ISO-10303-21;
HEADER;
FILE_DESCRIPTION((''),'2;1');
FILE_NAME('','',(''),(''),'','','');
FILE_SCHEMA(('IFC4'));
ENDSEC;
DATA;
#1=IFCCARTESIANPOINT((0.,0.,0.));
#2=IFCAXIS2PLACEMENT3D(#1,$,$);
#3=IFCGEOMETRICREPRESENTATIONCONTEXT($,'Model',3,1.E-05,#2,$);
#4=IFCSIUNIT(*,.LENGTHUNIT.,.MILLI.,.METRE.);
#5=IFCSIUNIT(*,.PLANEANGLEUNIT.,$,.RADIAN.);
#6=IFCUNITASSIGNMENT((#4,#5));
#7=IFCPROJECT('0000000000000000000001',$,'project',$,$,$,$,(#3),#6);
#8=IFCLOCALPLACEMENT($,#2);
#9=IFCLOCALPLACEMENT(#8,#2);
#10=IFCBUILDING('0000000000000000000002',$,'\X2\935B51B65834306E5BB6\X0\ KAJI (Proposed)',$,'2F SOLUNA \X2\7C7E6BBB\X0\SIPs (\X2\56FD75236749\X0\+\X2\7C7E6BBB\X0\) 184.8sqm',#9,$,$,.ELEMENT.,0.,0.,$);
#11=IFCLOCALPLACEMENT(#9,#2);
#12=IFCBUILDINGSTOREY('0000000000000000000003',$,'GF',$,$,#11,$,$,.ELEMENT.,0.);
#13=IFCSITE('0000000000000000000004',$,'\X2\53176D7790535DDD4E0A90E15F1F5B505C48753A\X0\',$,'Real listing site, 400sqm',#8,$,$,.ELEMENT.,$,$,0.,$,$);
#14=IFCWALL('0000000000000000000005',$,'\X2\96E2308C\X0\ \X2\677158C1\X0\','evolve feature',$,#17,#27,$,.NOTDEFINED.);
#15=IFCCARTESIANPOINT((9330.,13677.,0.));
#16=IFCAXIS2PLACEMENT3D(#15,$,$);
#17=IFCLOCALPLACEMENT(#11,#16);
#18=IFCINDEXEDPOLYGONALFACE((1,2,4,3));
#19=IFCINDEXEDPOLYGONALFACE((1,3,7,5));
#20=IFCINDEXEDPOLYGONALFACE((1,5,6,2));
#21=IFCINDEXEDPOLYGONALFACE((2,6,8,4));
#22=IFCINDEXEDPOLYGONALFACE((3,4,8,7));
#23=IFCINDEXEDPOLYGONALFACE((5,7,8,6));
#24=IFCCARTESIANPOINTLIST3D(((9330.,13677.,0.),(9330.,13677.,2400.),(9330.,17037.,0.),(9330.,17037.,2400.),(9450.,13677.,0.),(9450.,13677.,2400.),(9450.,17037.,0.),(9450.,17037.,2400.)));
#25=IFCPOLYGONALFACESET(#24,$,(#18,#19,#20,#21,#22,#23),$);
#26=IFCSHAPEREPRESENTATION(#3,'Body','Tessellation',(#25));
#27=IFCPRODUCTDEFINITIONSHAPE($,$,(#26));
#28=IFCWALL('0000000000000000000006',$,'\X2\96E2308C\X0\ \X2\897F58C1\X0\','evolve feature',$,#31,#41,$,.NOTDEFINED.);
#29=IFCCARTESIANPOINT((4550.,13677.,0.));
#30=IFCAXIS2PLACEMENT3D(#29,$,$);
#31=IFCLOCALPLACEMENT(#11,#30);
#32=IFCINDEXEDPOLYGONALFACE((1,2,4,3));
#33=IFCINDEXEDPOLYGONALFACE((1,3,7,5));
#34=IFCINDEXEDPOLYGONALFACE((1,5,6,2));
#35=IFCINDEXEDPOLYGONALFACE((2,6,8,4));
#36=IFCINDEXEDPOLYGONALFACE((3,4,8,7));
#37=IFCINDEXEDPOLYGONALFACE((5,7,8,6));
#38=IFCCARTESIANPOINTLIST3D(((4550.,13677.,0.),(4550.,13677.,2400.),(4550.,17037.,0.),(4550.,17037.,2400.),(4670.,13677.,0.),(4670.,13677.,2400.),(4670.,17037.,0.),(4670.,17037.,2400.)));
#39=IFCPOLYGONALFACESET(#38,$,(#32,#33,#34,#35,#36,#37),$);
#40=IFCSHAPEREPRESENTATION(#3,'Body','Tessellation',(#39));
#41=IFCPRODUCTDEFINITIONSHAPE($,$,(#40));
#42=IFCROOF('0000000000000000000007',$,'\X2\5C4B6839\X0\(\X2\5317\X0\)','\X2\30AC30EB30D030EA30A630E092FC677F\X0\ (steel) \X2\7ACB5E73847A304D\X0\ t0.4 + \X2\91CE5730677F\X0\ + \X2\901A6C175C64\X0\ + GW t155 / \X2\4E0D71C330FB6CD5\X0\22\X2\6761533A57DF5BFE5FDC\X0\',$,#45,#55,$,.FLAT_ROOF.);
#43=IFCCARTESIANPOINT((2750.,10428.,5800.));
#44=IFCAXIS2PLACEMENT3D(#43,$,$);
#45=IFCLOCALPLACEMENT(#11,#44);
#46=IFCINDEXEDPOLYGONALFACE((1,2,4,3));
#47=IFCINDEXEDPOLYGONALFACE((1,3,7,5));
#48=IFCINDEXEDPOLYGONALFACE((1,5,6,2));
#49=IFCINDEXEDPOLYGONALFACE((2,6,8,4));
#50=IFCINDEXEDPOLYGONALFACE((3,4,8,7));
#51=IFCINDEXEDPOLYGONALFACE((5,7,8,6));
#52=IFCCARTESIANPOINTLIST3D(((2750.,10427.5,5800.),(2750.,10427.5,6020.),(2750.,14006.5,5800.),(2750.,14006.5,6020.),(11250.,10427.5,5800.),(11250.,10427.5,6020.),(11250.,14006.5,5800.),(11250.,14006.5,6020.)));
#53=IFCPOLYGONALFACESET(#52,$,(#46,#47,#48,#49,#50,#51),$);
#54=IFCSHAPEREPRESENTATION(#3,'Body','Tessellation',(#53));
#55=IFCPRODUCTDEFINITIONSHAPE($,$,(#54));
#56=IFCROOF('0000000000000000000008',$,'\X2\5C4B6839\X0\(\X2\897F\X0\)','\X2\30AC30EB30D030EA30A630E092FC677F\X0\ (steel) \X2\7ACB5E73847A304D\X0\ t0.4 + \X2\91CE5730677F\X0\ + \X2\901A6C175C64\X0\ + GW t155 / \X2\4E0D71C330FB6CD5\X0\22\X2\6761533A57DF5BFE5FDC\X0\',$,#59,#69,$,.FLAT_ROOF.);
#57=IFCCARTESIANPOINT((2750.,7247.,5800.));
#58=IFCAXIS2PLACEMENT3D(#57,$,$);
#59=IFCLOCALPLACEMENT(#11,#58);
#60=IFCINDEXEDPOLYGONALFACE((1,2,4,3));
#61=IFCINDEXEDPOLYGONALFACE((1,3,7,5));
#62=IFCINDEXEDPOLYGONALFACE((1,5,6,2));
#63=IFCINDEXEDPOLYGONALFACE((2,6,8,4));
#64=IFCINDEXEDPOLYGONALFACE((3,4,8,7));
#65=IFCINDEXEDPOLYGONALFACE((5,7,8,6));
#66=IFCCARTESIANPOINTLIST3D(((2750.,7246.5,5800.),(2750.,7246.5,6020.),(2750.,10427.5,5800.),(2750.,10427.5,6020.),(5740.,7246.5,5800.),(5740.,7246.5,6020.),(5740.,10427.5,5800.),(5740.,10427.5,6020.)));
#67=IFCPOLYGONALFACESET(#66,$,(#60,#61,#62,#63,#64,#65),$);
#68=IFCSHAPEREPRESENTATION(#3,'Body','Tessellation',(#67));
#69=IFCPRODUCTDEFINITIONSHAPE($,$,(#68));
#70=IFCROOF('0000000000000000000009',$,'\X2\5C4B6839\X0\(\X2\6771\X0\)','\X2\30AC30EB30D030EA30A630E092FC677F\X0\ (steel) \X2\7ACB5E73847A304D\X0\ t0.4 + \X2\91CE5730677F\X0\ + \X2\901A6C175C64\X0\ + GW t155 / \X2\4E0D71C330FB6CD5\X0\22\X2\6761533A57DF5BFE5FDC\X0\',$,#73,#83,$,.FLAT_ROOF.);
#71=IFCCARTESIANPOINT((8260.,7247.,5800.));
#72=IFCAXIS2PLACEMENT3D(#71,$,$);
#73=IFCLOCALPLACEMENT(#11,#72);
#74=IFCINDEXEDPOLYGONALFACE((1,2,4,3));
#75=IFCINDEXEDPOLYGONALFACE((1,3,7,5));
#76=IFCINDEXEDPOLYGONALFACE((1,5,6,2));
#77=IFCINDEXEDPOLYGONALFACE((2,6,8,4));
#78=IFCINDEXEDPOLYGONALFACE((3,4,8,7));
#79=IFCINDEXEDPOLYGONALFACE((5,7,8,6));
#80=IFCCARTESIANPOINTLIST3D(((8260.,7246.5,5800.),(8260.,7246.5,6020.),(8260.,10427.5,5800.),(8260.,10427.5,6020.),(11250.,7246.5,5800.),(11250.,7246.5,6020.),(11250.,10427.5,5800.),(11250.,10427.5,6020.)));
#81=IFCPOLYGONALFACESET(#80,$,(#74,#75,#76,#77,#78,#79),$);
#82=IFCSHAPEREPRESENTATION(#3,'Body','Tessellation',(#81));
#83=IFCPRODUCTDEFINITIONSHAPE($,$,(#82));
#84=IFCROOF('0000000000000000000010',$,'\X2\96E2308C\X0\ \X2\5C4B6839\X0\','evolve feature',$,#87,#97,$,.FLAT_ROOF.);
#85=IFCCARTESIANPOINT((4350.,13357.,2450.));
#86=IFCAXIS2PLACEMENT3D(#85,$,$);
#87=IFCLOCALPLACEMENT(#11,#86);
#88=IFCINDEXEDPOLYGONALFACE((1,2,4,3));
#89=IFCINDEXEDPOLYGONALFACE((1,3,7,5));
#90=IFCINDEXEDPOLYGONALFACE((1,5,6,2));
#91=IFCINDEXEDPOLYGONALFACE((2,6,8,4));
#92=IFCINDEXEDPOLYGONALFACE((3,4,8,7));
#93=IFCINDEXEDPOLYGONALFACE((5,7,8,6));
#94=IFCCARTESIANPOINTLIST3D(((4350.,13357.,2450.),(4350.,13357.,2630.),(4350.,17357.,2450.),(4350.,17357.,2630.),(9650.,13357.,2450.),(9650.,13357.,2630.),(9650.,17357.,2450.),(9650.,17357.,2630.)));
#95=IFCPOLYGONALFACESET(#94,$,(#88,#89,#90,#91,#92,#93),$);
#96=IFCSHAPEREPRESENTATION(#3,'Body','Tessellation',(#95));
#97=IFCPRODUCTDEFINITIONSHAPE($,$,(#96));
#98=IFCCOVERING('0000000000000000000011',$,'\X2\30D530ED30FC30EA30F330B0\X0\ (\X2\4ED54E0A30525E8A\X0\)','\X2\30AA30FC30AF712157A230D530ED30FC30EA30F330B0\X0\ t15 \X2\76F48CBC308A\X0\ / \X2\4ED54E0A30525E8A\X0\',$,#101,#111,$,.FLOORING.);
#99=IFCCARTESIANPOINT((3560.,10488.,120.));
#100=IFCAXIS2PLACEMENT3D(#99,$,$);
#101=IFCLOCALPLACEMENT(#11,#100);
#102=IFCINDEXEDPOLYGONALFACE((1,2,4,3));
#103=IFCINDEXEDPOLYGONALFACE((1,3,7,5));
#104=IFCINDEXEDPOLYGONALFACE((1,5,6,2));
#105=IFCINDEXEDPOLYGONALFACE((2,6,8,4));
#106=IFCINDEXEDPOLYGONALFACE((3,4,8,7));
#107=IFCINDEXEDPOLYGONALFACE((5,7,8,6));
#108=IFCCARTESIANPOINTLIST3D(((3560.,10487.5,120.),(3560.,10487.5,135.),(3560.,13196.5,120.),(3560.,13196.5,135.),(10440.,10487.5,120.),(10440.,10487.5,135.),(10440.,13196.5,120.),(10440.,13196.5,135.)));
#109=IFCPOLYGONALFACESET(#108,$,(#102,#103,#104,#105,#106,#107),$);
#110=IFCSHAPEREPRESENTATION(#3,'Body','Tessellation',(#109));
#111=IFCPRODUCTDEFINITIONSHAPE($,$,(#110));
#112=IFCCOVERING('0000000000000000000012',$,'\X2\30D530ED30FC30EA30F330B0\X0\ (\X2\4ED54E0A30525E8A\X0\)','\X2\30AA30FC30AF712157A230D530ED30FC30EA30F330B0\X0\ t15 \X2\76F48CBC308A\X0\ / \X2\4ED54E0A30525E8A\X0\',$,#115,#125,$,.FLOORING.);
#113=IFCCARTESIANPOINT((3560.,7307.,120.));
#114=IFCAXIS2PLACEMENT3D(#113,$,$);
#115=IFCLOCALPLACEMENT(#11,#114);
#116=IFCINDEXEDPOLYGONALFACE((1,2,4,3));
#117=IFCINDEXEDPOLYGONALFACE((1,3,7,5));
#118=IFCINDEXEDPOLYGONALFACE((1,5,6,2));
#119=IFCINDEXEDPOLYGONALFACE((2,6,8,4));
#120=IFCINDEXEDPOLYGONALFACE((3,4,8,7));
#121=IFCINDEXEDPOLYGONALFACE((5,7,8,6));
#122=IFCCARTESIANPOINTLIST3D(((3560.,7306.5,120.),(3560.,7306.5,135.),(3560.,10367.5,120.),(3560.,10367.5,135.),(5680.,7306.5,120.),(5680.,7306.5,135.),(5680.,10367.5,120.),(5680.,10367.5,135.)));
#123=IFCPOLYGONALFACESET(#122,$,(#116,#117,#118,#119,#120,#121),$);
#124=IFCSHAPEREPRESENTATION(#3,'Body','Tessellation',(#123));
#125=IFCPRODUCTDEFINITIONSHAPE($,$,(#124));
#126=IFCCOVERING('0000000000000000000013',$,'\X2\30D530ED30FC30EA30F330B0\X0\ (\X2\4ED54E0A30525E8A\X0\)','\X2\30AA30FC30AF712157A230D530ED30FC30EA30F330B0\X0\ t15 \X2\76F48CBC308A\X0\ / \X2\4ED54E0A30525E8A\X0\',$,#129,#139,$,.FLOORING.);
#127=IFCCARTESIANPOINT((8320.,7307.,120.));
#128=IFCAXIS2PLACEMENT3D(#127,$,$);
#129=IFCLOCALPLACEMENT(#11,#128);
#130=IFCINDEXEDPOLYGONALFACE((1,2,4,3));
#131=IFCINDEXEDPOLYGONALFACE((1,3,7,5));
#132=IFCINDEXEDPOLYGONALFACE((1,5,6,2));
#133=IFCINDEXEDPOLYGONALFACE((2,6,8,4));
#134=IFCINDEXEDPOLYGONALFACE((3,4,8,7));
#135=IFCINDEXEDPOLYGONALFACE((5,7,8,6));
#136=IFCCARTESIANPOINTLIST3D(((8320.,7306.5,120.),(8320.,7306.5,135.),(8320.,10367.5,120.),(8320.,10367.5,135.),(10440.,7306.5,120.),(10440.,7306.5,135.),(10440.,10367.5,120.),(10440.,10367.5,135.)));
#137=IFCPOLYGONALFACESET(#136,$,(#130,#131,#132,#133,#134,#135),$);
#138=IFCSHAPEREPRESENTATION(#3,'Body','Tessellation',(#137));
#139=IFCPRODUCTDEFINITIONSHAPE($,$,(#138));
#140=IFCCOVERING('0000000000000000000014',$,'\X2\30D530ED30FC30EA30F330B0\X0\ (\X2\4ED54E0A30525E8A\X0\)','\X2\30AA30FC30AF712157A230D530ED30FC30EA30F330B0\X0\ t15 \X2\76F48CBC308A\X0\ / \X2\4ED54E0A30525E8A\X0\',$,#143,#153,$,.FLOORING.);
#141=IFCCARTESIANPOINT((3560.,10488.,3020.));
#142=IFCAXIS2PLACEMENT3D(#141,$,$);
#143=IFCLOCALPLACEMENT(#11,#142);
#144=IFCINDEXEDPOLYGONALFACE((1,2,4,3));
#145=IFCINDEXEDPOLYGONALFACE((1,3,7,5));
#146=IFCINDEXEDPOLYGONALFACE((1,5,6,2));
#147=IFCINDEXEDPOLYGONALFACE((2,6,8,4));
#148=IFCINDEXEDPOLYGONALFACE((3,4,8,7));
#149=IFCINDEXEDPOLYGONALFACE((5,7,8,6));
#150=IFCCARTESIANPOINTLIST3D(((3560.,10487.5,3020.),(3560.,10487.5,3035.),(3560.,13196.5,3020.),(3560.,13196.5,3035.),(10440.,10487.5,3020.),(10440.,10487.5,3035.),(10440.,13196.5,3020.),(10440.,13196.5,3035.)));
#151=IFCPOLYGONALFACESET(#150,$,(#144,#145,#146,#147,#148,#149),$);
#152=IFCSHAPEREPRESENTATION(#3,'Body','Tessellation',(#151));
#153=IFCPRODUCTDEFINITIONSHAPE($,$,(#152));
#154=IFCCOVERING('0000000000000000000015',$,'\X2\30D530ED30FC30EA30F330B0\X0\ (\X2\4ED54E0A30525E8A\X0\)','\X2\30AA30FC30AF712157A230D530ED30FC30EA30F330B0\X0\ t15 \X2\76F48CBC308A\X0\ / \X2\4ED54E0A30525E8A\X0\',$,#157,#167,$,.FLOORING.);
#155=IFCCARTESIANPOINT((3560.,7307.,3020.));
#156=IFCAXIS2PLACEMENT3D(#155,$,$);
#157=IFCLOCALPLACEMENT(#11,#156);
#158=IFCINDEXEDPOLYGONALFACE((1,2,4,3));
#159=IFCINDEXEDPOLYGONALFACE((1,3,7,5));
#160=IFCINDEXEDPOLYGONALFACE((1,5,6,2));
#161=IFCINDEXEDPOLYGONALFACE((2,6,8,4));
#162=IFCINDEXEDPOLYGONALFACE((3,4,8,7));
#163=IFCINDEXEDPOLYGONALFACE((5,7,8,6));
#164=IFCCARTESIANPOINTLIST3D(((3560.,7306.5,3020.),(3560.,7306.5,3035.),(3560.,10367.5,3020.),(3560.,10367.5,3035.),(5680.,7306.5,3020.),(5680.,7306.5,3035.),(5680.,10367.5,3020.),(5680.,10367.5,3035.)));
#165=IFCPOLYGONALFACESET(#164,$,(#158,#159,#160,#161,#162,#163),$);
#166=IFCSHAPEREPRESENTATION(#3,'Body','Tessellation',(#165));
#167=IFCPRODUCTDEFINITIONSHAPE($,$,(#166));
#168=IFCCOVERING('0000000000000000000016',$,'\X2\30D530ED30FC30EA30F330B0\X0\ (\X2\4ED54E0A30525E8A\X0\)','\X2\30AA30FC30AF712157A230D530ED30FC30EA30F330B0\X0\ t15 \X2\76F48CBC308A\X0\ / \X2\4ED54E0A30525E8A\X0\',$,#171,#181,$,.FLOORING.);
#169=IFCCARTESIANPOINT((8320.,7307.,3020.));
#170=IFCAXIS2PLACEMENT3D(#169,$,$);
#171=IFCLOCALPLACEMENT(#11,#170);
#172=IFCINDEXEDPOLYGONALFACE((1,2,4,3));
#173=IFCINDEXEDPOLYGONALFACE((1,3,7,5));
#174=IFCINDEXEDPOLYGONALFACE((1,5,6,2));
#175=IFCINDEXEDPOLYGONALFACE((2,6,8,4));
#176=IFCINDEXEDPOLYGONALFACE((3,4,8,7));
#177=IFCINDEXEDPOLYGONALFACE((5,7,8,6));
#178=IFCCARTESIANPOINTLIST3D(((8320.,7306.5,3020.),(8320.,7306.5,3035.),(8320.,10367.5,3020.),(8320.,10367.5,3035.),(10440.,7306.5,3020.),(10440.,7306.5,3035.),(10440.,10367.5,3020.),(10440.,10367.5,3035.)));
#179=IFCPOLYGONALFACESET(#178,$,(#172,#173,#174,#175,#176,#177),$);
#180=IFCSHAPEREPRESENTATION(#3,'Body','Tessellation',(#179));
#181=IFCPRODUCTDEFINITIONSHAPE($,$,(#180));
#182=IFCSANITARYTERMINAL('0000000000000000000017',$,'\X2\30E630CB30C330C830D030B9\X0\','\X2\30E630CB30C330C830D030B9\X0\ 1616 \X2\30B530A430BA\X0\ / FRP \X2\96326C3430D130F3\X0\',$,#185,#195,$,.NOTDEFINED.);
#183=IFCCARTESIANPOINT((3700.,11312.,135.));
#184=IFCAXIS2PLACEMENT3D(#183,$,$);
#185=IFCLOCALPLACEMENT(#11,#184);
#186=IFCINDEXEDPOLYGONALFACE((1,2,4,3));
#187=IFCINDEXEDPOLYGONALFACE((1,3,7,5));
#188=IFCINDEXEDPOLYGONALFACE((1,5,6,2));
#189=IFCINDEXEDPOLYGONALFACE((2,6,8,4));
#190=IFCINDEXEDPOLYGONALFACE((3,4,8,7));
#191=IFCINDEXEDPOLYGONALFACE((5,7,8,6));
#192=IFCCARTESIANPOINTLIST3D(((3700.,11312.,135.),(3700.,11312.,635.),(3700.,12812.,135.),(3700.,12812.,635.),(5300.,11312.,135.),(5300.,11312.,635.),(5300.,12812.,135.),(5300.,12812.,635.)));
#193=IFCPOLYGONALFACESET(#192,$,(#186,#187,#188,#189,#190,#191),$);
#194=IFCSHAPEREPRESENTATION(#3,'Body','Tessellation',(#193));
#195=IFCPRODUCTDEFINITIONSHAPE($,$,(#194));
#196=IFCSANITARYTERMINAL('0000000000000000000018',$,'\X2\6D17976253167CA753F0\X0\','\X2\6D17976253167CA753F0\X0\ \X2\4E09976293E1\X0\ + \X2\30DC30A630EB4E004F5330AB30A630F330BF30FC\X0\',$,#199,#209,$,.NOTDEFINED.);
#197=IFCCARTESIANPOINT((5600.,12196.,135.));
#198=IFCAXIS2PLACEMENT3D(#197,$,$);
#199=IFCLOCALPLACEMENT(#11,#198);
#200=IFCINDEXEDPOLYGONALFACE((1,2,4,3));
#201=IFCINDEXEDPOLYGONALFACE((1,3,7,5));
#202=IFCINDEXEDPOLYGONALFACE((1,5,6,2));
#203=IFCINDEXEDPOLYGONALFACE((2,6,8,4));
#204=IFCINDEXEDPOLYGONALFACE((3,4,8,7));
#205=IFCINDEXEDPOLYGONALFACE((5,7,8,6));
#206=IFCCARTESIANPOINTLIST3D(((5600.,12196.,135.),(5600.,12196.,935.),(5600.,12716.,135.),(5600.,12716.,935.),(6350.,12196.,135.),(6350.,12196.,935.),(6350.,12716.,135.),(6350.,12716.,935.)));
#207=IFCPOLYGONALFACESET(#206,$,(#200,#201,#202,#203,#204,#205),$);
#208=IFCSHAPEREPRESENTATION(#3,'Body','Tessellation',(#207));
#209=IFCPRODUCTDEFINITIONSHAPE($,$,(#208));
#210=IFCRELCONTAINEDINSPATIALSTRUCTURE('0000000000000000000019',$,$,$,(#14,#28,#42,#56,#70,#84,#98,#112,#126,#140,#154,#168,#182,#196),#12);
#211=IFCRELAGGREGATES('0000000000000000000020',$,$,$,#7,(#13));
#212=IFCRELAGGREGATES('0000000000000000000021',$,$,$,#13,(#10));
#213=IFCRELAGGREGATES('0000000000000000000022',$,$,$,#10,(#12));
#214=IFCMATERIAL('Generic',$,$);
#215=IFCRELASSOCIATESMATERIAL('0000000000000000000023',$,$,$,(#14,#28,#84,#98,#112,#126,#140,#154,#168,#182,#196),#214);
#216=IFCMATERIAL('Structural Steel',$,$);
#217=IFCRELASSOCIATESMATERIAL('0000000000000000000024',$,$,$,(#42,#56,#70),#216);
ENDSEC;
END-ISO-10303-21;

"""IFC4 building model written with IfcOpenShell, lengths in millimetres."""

from ifc_helpers import new_model, si_unit, frame, frame_2d, origin, place, context, project, spatial, rectangle, extrude, material, element, save


model = new_model("IFC4")

# Units and contexts
model_context = context("Model", 3, precision=1e-05, world=origin())
ifc_project = project(units=[si_unit("LENGTHUNIT", "METRE", prefix="MILLI"), si_unit("PLANEANGLEUNIT", "RADIAN")], contexts=[model_context])

# Site, building, storey
site_placement = place(None, origin())
site = spatial("IfcSite", under=ifc_project, at=site_placement, Name="北海道川上郡弟子屈町", ObjectType="Real listing site, 400sqm", CompositionType="ELEMENT", RefElevation=0.0)
building_placement = place(site_placement, origin())
building = spatial("IfcBuilding", under=site, at=building_placement, Name="鍛冶場の家 KAJI (Proposed)", ObjectType="2F SOLUNA 籾殻SIPs (国産杉+籾殻) 184.8sqm", CompositionType="ELEMENT", ElevationOfRefHeight=0.0, ElevationOfTerrain=0.0)
storey_placement = place(building_placement, origin())
storey = spatial("IfcBuildingStorey", under=building, at=storey_placement, Name="GF", CompositionType="ELEMENT", Elevation=0.0)

# Shared definitions
ifc_material_1 = material(Name="Generic")

# Walls
wall_1_placement = place(storey_placement, frame((9330.0, 13677.0, 0.0)))
element("IfcWall", 1, at=wall_1_placement, inside=storey, material=ifc_material_1, Name="離れ 東壁", Description="evolve feature", PredefinedType="NOTDEFINED", context=model_context, shape_type="SweptSolid", body=[
    extrude(rectangle(XDim=120.0, YDim=3360.0, at=frame_2d((60.0, 1680.0))), frame((9330.0, 13677.0, 0.0)), (0.0, 0.0, 1.0), 2400.0),
])
wall_2_placement = place(storey_placement, frame((4550.0, 13677.0, 0.0)))
element("IfcWall", 2, at=wall_2_placement, inside=storey, material=ifc_material_1, Name="離れ 西壁", Description="evolve feature", PredefinedType="NOTDEFINED", context=model_context, shape_type="SweptSolid", body=[
    extrude(rectangle(XDim=120.0, YDim=3360.0, at=frame_2d((60.0, 1680.0))), frame((4550.0, 13677.0, 0.0)), (0.0, 0.0, 1.0), 2400.0),
])

# Roofs
ifc_material_2 = material(Name="Structural Steel")
for number, where, name in (
    (3, (2750.0, 10428.0, 5800.0), "屋根(北)"),
):
    element("IfcRoof", number, at=place(storey_placement, frame(where)), inside=storey, material=ifc_material_2, Name=name, Description="ガルバリウム鋼板 (steel) 立平葺き t0.4 + 野地板 + 通気層 + GW t155 / 不燃・法22条区域対応", PredefinedType="FLAT_ROOF", context=model_context, shape_type="SweptSolid", body=[
        extrude(rectangle(XDim=8500.0, YDim=3579.0, at=frame_2d((4250.0, 1789.0))), frame((2750.0, 10428.0, 5800.0)), (0.0, 0.0, 1.0), 220.0),
    ])
roof_1_placement = place(storey_placement, frame((2750.0, 7247.0, 5800.0)))
element("IfcRoof", 4, at=roof_1_placement, inside=storey, material=ifc_material_2, Name="屋根(西)", Description="ガルバリウム鋼板 (steel) 立平葺き t0.4 + 野地板 + 通気層 + GW t155 / 不燃・法22条区域対応", PredefinedType="FLAT_ROOF", context=model_context, shape_type="SweptSolid", body=[
    extrude(rectangle(XDim=2990.0, YDim=3181.0, at=frame_2d((1495.0, 1590.0))), frame((2750.0, 7247.0, 5800.0)), (0.0, 0.0, 1.0), 220.0),
])
roof_2_placement = place(storey_placement, frame((8260.0, 7247.0, 5800.0)))
element("IfcRoof", 5, at=roof_2_placement, inside=storey, material=ifc_material_2, Name="屋根(東)", Description="ガルバリウム鋼板 (steel) 立平葺き t0.4 + 野地板 + 通気層 + GW t155 / 不燃・法22条区域対応", PredefinedType="FLAT_ROOF", context=model_context, shape_type="SweptSolid", body=[
    extrude(rectangle(XDim=2990.0, YDim=3181.0, at=frame_2d((1495.0, 1590.0))), frame((8260.0, 7247.0, 5800.0)), (0.0, 0.0, 1.0), 220.0),
])
roof_3_placement = place(storey_placement, frame((4350.0, 13357.0, 2450.0)))
element("IfcRoof", 6, at=roof_3_placement, inside=storey, material=ifc_material_1, Name="離れ 屋根", Description="evolve feature", PredefinedType="FLAT_ROOF", context=model_context, shape_type="SweptSolid", body=[
    extrude(rectangle(XDim=5300.0, YDim=4000.0, at=frame_2d((2650.0, 2000.0))), frame((4350.0, 13357.0, 2450.0)), (0.0, 0.0, 1.0), 180.0),
])

# Coverings
covering_1_placement = place(storey_placement, frame((3560.0, 10488.0, 120.0)))
element("IfcCovering", 7, at=covering_1_placement, inside=storey, material=ifc_material_1, Name="フローリング (仕上げ床)", Description="オーク無垢フローリング t15 直貼り / 仕上げ床", PredefinedType="FLOORING", context=model_context, shape_type="SweptSolid", body=[
    extrude(rectangle(XDim=6880.0, YDim=2709.0, at=frame_2d((3440.0, 1354.0))), frame((3560.0, 10488.0, 120.0)), (0.0, 0.0, 1.0), 15.0),
])
covering_2_placement = place(storey_placement, frame((3560.0, 7307.0, 120.0)))
element("IfcCovering", 8, at=covering_2_placement, inside=storey, material=ifc_material_1, Name="フローリング (仕上げ床)", Description="オーク無垢フローリング t15 直貼り / 仕上げ床", PredefinedType="FLOORING", context=model_context, shape_type="SweptSolid", body=[
    extrude(rectangle(XDim=2120.0, YDim=3061.0, at=frame_2d((1060.0, 1530.0))), frame((3560.0, 7307.0, 120.0)), (0.0, 0.0, 1.0), 15.0),
])
covering_3_placement = place(storey_placement, frame((8320.0, 7307.0, 120.0)))
element("IfcCovering", 9, at=covering_3_placement, inside=storey, material=ifc_material_1, Name="フローリング (仕上げ床)", Description="オーク無垢フローリング t15 直貼り / 仕上げ床", PredefinedType="FLOORING", context=model_context, shape_type="SweptSolid", body=[
    extrude(rectangle(XDim=2120.0, YDim=3061.0, at=frame_2d((1060.0, 1530.0))), frame((8320.0, 7307.0, 120.0)), (0.0, 0.0, 1.0), 15.0),
])
covering_4_placement = place(storey_placement, frame((3560.0, 10488.0, 3020.0)))
element("IfcCovering", 10, at=covering_4_placement, inside=storey, material=ifc_material_1, Name="フローリング (仕上げ床)", Description="オーク無垢フローリング t15 直貼り / 仕上げ床", PredefinedType="FLOORING", context=model_context, shape_type="SweptSolid", body=[
    extrude(rectangle(XDim=6880.0, YDim=2709.0, at=frame_2d((3440.0, 1354.0))), frame((3560.0, 10488.0, 3020.0)), (0.0, 0.0, 1.0), 15.0),
])
covering_5_placement = place(storey_placement, frame((3560.0, 7307.0, 3020.0)))
element("IfcCovering", 11, at=covering_5_placement, inside=storey, material=ifc_material_1, Name="フローリング (仕上げ床)", Description="オーク無垢フローリング t15 直貼り / 仕上げ床", PredefinedType="FLOORING", context=model_context, shape_type="SweptSolid", body=[
    extrude(rectangle(XDim=2120.0, YDim=3061.0, at=frame_2d((1060.0, 1530.0))), frame((3560.0, 7307.0, 3020.0)), (0.0, 0.0, 1.0), 15.0),
])
covering_6_placement = place(storey_placement, frame((8320.0, 7307.0, 3020.0)))
element("IfcCovering", 12, at=covering_6_placement, inside=storey, material=ifc_material_1, Name="フローリング (仕上げ床)", Description="オーク無垢フローリング t15 直貼り / 仕上げ床", PredefinedType="FLOORING", context=model_context, shape_type="SweptSolid", body=[
    extrude(rectangle(XDim=2120.0, YDim=3061.0, at=frame_2d((1060.0, 1530.0))), frame((8320.0, 7307.0, 3020.0)), (0.0, 0.0, 1.0), 15.0),
])

# Sanitary terminals
sanitary_terminal_1_placement = place(storey_placement, frame((3700.0, 11312.0, 135.0)))
element("IfcSanitaryTerminal", 13, at=sanitary_terminal_1_placement, inside=storey, material=ifc_material_1, Name="ユニットバス", Description="ユニットバス 1616 サイズ / FRP 防水パン", PredefinedType="NOTDEFINED", context=model_context, shape_type="SweptSolid", body=[
    extrude(rectangle(XDim=1600.0, YDim=1500.0, at=frame_2d((800.0, 750.0))), frame((3700.0, 11312.0, 135.0)), (0.0, 0.0, 1.0), 500.0),
])
sanitary_terminal_2_placement = place(storey_placement, frame((5600.0, 12196.0, 135.0)))
element("IfcSanitaryTerminal", 14, at=sanitary_terminal_2_placement, inside=storey, material=ifc_material_1, Name="洗面化粧台", Description="洗面化粧台 三面鏡 + ボウル一体カウンター", PredefinedType="NOTDEFINED", context=model_context, shape_type="SweptSolid", body=[
    extrude(rectangle(XDim=750.0, YDim=520.0, at=frame_2d((375.0, 260.0))), frame((5600.0, 12196.0, 135.0)), (0.0, 0.0, 1.0), 800.0),
])

save(model, "model.ifc")
